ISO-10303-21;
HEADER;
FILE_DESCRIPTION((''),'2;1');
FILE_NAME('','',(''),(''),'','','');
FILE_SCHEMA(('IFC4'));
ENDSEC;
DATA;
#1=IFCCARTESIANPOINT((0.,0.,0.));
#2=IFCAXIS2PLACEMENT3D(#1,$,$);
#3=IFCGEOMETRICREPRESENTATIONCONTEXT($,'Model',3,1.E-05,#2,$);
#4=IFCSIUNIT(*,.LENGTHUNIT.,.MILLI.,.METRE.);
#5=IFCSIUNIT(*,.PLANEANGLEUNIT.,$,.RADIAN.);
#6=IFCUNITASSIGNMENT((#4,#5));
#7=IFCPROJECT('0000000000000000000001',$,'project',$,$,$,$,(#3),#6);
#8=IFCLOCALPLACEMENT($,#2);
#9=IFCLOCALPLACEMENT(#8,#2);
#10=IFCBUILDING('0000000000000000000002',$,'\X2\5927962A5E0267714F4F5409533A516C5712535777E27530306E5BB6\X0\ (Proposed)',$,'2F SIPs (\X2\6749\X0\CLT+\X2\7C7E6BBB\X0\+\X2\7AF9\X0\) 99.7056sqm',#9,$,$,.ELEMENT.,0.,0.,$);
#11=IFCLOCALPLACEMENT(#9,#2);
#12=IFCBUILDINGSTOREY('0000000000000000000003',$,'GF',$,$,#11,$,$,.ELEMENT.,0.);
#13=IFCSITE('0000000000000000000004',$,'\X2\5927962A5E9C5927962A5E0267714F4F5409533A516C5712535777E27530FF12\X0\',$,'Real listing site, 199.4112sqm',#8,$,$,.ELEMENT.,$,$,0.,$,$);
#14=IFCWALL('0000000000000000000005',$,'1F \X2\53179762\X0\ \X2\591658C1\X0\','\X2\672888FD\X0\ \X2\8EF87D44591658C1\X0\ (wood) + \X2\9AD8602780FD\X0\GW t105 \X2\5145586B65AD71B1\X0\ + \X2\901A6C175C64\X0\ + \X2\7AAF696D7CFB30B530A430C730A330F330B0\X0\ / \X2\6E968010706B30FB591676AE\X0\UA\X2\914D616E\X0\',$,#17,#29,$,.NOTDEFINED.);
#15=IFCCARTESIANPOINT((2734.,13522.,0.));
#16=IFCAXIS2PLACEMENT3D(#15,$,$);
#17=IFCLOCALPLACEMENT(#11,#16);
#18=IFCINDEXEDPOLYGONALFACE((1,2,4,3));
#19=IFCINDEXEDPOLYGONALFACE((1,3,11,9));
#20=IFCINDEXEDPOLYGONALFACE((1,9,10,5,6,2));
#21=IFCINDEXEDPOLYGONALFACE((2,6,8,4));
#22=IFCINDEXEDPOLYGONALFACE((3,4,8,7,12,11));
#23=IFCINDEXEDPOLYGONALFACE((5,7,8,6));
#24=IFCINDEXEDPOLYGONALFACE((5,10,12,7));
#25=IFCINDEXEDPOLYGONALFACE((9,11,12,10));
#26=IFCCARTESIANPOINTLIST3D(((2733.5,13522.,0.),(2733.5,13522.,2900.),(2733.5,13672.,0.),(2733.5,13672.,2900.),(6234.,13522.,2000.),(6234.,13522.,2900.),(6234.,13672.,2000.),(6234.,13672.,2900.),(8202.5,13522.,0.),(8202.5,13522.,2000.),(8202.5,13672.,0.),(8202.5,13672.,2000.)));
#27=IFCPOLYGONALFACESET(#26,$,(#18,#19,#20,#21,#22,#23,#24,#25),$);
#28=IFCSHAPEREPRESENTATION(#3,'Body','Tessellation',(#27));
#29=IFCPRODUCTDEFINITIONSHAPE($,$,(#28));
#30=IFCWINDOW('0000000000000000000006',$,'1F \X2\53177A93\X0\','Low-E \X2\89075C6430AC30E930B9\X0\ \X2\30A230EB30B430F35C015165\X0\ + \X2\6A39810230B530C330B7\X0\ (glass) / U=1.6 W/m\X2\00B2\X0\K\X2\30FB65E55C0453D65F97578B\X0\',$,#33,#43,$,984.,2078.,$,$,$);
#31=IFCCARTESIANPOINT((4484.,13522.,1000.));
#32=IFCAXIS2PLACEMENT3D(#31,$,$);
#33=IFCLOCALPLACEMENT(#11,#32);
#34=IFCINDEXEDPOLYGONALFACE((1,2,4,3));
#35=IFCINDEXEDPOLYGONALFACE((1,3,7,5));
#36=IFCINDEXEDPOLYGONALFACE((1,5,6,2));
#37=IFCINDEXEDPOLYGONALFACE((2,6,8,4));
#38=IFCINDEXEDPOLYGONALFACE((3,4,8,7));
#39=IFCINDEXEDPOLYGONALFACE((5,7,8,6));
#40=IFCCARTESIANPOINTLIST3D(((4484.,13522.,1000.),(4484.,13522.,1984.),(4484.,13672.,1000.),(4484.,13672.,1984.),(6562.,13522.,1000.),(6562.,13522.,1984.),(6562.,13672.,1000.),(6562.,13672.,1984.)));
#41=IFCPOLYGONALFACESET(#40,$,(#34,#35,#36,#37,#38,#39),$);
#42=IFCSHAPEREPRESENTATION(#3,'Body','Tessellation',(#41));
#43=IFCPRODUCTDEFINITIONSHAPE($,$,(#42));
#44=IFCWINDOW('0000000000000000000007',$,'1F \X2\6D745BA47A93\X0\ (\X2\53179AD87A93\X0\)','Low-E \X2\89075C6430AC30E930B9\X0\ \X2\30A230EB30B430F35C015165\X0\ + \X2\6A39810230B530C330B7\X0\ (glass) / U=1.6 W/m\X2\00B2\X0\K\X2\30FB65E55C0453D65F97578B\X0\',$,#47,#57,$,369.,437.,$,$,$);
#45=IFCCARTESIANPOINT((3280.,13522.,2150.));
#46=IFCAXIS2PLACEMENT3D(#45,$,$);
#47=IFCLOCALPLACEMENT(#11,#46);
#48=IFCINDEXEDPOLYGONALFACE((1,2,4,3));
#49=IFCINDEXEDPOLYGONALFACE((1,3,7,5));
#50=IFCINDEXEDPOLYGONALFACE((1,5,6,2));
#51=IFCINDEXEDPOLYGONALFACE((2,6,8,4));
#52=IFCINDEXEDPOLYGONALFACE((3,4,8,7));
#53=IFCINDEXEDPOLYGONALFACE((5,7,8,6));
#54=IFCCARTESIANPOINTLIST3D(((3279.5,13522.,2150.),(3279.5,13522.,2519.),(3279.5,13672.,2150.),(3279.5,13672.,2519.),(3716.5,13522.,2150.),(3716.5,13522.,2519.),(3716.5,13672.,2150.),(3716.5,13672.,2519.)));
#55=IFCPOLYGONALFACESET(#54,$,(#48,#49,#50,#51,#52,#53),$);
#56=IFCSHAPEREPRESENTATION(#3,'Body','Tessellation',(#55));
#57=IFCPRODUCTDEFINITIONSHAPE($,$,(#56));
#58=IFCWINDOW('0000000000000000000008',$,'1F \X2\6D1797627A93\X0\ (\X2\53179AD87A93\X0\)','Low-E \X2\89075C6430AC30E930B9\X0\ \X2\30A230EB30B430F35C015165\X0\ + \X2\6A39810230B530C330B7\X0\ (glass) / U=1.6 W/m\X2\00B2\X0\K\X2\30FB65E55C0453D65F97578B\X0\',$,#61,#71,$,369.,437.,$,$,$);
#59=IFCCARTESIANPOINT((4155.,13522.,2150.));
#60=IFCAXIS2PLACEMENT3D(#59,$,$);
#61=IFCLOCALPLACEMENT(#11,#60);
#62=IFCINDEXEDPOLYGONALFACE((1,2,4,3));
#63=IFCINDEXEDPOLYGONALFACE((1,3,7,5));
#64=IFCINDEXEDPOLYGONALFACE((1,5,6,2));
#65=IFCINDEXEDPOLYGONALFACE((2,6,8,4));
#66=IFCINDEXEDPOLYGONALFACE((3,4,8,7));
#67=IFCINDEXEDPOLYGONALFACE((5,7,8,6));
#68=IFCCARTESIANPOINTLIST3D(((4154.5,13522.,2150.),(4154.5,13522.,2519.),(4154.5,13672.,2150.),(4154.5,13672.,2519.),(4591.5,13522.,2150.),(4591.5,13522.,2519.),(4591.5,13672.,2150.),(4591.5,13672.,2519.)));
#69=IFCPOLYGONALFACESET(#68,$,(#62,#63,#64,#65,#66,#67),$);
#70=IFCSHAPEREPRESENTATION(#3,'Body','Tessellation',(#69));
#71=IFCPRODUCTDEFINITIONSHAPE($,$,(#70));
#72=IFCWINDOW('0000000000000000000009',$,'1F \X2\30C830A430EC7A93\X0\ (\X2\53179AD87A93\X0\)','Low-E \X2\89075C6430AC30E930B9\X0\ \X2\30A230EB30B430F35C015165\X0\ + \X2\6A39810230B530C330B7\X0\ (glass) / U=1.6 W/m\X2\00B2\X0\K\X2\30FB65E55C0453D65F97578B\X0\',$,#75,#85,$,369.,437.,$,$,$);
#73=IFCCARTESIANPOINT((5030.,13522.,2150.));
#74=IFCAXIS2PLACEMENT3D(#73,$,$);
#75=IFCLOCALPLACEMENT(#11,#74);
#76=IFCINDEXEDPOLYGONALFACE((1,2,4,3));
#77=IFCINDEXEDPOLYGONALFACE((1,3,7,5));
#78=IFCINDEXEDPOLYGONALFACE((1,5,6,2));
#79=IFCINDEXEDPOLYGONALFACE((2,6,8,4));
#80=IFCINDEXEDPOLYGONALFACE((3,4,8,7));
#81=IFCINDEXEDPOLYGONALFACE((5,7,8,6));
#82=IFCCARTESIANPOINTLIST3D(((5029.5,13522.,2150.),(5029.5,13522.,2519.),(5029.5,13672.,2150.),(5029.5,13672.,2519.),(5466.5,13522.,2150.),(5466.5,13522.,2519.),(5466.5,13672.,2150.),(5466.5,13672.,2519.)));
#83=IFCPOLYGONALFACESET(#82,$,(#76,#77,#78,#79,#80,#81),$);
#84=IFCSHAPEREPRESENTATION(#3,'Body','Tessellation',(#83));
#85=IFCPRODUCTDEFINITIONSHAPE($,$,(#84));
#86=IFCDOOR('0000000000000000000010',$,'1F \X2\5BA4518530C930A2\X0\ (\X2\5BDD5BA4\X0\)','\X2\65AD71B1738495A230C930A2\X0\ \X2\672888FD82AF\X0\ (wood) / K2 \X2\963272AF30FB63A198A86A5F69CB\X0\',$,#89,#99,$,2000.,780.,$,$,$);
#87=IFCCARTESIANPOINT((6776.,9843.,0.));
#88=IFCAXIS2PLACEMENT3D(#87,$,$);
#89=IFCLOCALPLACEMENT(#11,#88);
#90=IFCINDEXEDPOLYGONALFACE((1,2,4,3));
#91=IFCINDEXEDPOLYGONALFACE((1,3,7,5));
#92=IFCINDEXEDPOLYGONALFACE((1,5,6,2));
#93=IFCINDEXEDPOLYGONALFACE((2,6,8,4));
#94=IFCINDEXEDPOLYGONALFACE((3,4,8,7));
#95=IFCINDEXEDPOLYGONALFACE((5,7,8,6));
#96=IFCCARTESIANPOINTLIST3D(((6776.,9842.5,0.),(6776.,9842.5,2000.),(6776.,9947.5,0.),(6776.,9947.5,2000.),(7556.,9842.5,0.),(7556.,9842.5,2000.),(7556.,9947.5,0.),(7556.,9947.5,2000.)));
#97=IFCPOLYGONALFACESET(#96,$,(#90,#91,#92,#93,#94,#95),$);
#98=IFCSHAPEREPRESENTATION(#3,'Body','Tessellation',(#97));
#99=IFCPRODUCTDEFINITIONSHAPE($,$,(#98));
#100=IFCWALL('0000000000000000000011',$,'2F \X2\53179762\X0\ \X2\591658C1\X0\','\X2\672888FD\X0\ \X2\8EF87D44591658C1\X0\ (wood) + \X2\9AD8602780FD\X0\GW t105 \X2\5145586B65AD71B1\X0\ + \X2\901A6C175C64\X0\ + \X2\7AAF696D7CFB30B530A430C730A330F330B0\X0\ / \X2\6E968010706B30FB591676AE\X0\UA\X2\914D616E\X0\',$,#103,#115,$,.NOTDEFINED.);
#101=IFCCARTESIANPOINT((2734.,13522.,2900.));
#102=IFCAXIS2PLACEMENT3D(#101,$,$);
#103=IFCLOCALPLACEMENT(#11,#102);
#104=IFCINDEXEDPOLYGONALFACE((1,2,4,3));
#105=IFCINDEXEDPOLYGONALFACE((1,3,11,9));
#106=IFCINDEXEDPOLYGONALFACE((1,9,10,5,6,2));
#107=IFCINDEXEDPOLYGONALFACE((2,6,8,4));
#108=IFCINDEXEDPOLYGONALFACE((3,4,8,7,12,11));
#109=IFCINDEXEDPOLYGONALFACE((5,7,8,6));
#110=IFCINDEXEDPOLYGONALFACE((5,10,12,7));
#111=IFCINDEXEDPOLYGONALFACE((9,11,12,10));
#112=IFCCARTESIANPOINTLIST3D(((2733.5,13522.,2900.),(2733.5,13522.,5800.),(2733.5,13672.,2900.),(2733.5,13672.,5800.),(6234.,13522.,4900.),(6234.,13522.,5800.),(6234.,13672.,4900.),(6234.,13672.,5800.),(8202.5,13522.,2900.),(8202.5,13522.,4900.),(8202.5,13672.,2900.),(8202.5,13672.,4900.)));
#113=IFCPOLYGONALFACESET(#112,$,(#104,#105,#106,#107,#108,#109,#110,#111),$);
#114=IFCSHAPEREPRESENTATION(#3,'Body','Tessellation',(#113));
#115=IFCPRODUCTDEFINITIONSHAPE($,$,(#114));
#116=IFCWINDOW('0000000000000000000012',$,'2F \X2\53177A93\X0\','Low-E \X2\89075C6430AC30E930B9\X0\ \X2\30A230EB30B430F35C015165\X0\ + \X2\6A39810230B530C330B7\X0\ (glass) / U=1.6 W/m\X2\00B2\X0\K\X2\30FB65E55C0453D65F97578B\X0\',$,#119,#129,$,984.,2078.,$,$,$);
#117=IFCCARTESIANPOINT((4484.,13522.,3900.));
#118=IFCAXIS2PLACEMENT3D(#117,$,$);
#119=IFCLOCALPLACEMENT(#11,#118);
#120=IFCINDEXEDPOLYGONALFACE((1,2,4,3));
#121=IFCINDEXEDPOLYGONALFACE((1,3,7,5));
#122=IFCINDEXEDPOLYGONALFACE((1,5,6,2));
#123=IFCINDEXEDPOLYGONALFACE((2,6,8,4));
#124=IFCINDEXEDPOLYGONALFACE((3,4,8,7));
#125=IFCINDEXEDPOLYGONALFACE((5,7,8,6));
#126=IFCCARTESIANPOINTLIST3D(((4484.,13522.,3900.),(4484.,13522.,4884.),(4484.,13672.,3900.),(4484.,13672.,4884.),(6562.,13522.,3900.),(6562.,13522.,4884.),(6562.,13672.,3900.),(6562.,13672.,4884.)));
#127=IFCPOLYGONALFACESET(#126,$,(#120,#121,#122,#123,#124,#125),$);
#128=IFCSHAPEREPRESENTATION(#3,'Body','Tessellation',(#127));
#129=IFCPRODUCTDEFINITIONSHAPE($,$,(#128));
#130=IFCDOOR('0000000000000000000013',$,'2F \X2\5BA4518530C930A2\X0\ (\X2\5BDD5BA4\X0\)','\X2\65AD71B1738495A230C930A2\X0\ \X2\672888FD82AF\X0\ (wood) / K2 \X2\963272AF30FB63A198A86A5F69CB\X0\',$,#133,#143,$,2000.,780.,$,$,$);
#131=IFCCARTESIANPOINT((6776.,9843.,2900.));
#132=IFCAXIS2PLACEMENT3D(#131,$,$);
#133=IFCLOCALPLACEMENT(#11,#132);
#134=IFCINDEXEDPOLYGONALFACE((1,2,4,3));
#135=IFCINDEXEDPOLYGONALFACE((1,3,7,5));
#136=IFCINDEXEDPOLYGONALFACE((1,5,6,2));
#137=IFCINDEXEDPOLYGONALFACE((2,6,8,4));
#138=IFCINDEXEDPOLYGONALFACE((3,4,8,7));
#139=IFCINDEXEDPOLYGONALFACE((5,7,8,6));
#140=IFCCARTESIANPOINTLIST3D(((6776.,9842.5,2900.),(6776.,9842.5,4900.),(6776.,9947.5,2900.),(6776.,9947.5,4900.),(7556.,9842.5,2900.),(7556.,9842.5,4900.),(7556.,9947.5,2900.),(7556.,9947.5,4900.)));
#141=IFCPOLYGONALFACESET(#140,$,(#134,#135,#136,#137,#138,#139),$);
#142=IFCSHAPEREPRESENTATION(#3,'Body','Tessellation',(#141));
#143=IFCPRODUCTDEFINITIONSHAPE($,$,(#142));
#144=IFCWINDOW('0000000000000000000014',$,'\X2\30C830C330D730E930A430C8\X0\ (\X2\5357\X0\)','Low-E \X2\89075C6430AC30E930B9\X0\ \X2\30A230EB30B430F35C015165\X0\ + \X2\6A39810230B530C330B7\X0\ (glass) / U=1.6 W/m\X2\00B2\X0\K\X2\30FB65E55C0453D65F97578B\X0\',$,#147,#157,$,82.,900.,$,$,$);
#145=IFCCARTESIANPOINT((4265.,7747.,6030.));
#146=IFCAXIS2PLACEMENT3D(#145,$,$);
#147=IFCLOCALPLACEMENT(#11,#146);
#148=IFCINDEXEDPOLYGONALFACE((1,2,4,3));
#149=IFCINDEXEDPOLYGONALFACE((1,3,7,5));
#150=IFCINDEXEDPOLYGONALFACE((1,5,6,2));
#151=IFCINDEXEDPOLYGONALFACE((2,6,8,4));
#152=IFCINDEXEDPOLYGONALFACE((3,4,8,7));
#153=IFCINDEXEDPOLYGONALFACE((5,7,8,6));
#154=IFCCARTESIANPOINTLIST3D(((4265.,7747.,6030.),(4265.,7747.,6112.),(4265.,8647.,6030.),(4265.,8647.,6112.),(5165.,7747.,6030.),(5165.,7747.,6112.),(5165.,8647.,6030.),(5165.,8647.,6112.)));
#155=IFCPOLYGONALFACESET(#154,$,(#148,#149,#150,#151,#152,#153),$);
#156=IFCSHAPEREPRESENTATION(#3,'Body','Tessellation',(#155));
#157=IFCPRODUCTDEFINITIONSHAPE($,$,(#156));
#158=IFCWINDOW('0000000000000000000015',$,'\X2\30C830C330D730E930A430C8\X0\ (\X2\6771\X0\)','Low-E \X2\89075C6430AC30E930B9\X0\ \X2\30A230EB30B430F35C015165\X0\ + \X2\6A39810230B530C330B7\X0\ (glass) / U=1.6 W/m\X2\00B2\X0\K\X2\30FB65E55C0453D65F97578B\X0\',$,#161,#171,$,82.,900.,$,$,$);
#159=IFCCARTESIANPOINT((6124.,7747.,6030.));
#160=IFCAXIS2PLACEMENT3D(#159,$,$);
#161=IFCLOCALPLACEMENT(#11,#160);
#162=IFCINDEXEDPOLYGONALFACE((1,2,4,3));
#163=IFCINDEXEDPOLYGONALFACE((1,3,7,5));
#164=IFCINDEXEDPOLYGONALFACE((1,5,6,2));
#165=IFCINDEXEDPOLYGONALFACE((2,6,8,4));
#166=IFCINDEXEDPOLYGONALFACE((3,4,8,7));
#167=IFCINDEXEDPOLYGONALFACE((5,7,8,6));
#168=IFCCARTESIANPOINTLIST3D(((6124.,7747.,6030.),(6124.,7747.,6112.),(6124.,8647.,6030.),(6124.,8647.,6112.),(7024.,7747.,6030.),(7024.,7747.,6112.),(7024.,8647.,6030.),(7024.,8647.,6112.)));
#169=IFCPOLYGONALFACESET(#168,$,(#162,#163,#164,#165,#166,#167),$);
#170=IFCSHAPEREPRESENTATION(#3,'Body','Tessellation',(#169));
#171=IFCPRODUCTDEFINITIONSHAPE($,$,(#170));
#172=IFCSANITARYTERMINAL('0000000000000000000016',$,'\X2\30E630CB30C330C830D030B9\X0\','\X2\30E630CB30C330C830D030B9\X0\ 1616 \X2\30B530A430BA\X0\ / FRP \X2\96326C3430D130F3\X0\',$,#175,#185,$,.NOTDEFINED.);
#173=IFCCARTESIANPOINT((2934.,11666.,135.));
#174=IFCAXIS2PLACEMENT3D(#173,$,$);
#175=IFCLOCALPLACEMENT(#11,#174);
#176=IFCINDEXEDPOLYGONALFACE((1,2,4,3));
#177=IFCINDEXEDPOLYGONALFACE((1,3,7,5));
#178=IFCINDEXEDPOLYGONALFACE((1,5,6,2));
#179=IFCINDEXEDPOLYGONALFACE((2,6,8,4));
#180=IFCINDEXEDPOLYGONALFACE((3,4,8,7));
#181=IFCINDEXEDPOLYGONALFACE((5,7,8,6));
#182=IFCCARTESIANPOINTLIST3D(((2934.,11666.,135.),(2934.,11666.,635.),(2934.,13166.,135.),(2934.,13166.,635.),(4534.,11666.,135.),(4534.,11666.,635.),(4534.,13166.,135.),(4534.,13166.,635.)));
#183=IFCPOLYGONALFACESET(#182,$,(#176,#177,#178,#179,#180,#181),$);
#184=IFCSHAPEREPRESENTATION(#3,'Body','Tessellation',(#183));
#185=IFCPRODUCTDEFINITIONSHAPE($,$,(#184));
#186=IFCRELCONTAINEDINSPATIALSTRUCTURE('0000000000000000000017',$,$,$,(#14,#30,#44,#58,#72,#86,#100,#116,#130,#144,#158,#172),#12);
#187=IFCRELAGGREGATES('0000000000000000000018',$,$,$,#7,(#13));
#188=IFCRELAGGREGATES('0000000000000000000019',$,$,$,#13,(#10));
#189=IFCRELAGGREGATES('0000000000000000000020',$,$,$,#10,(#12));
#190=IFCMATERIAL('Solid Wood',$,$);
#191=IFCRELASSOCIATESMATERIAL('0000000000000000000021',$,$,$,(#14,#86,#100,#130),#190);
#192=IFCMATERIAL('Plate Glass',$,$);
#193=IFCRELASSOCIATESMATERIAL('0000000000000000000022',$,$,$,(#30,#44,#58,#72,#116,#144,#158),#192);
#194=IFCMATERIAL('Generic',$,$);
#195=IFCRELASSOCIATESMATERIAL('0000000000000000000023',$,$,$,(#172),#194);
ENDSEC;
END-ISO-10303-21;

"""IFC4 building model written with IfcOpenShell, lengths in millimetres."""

from ifc_helpers import new_model, si_unit, frame, frame_2d, origin, place, context, project, spatial, rectangle, extrude, material, element, fill, save


model = new_model("IFC4")

# Units and contexts
model_context = context("Model", 3, precision=1e-05, world=origin())
ifc_project = project(units=[si_unit("LENGTHUNIT", "METRE", prefix="MILLI"), si_unit("PLANEANGLEUNIT", "RADIAN")], contexts=[model_context])

# Site, building, storey
site_placement = place(None, origin())
site = spatial("IfcSite", under=ifc_project, at=site_placement, Name="大阪府大阪市東住吉区公園南矢田２", ObjectType="Real listing site, 199.4112sqm", CompositionType="ELEMENT", RefElevation=0.0)
building_placement = place(site_placement, origin())
building = spatial("IfcBuilding", under=site, at=building_placement, Name="大阪市東住吉区公園南矢田の家 (Proposed)", ObjectType="2F SIPs (杉CLT+籾殻+竹) 99.7056sqm", CompositionType="ELEMENT", ElevationOfRefHeight=0.0, ElevationOfTerrain=0.0)
storey_placement = place(building_placement, origin())
storey = spatial("IfcBuildingStorey", under=building, at=storey_placement, Name="GF", CompositionType="ELEMENT", Elevation=0.0)

# Wall, openings, windows
ifc_material_1 = material(Name="Solid Wood")
wall_1_placement = place(storey_placement, frame((2734.0, 13522.0, 0.0)))
wall_1 = element("IfcWall", 1, at=wall_1_placement, inside=storey, material=ifc_material_1, Name="1F 北面 外壁", Description="木製 軸組外壁 (wood) + 高性能GW t105 充填断熱 + 通気層 + 窯業系サイディング / 準耐火・外皮UA配慮", PredefinedType="NOTDEFINED", context=model_context, shape_type="SweptSolid", body=[
    extrude(rectangle(XDim=5469.0, YDim=150.0, at=frame_2d((2734.0, 75.0))), frame((2734.0, 13522.0, 0.0)), (0.0, 0.0, 1.0), 2900.0),
])
opening_1_placement = place(storey_placement, frame((4484.0, 13522.0, 1000.0)))
opening_1 = element("IfcOpeningElement", 2, at=opening_1_placement, cuts=wall_1, PredefinedType="NOTDEFINED", context=model_context, shape_type="SweptSolid", body=[
    extrude(rectangle(XDim=2078.0, YDim=150.0, at=frame_2d((1039.0, 75.0))), frame((4484.0, 13522.0, 1000.0)), (0.0, 0.0, 1.0), 984.0),
])
opening_2_placement = place(storey_placement, frame((3280.0, 13522.0, 2150.0)))
opening_2 = element("IfcOpeningElement", 3, at=opening_2_placement, cuts=wall_1, PredefinedType="NOTDEFINED", context=model_context, shape_type="SweptSolid", body=[
    extrude(rectangle(XDim=437.0, YDim=150.0, at=frame_2d((218.0, 75.0))), frame((3280.0, 13522.0, 2150.0)), (0.0, 0.0, 1.0), 369.0),
])
opening_3_placement = place(storey_placement, frame((4155.0, 13522.0, 2150.0)))
opening_3 = element("IfcOpeningElement", 4, at=opening_3_placement, cuts=wall_1, PredefinedType="NOTDEFINED", context=model_context, shape_type="SweptSolid", body=[
    extrude(rectangle(XDim=437.0, YDim=150.0, at=frame_2d((218.0, 75.0))), frame((4155.0, 13522.0, 2150.0)), (0.0, 0.0, 1.0), 369.0),
])
opening_4_placement = place(storey_placement, frame((5030.0, 13522.0, 2150.0)))
opening_4 = element("IfcOpeningElement", 5, at=opening_4_placement, cuts=wall_1, PredefinedType="NOTDEFINED", context=model_context, shape_type="SweptSolid", body=[
    extrude(rectangle(XDim=437.0, YDim=150.0, at=frame_2d((218.0, 75.0))), frame((5030.0, 13522.0, 2150.0)), (0.0, 0.0, 1.0), 369.0),
])
ifc_material_2 = material(Name="Plate Glass")
window_1_placement = place(storey_placement, frame((4484.0, 13522.0, 1000.0)))
window_1 = element("IfcWindow", 6, at=window_1_placement, inside=storey, material=ifc_material_2, Name="1F 北窓", Description="Low-E 複層ガラス アルゴン封入 + 樹脂サッシ (glass) / U=1.6 W/m²K・日射取得型", OverallHeight=984.0, OverallWidth=2078.0, context=model_context, shape_type="SweptSolid", body=[
    extrude(rectangle(XDim=2078.0, YDim=150.0, at=frame_2d((1039.0, 75.0))), frame((4484.0, 13522.0, 1000.0)), (0.0, 0.0, 1.0), 984.0),
])
fill(opening_1, window_1)
window_2_placement = place(storey_placement, frame((3280.0, 13522.0, 2150.0)))
window_2 = element("IfcWindow", 7, at=window_2_placement, inside=storey, material=ifc_material_2, Name="1F 浴室窓 (北高窓)", Description="Low-E 複層ガラス アルゴン封入 + 樹脂サッシ (glass) / U=1.6 W/m²K・日射取得型", OverallHeight=369.0, OverallWidth=437.0, context=model_context, shape_type="SweptSolid", body=[
    extrude(rectangle(XDim=437.0, YDim=150.0, at=frame_2d((218.0, 75.0))), frame((3280.0, 13522.0, 2150.0)), (0.0, 0.0, 1.0), 369.0),
])
fill(opening_2, window_2)
window_3_placement = place(storey_placement, frame((4155.0, 13522.0, 2150.0)))
window_3 = element("IfcWindow", 8, at=window_3_placement, inside=storey, material=ifc_material_2, Name="1F 洗面窓 (北高窓)", Description="Low-E 複層ガラス アルゴン封入 + 樹脂サッシ (glass) / U=1.6 W/m²K・日射取得型", OverallHeight=369.0, OverallWidth=437.0, context=model_context, shape_type="SweptSolid", body=[
    extrude(rectangle(XDim=437.0, YDim=150.0, at=frame_2d((218.0, 75.0))), frame((4155.0, 13522.0, 2150.0)), (0.0, 0.0, 1.0), 369.0),
])
fill(opening_3, window_3)
window_4_placement = place(storey_placement, frame((5030.0, 13522.0, 2150.0)))
window_4 = element("IfcWindow", 9, at=window_4_placement, inside=storey, material=ifc_material_2, Name="1F トイレ窓 (北高窓)", Description="Low-E 複層ガラス アルゴン封入 + 樹脂サッシ (glass) / U=1.6 W/m²K・日射取得型", OverallHeight=369.0, OverallWidth=437.0, context=model_context, shape_type="SweptSolid", body=[
    extrude(rectangle(XDim=437.0, YDim=150.0, at=frame_2d((218.0, 75.0))), frame((5030.0, 13522.0, 2150.0)), (0.0, 0.0, 1.0), 369.0),
])
fill(opening_4, window_4)

# Door
door_1_placement = place(storey_placement, frame((6776.0, 9843.0, 0.0)))
element("IfcDoor", 10, at=door_1_placement, inside=storey, material=ifc_material_1, Name="1F 室内ドア (寝室)", Description="断熱玄関ドア 木製芯 (wood) / K2 防犯・採風機構", OverallHeight=2000.0, OverallWidth=780.0, context=model_context, shape_type="SweptSolid", body=[
    extrude(rectangle(XDim=780.0, YDim=105.0, at=frame_2d((390.0, 52.0))), frame((6776.0, 9843.0, 0.0)), (0.0, 0.0, 1.0), 2000.0),
])

# Wall, opening, window
wall_2_placement = place(storey_placement, frame((2734.0, 13522.0, 2900.0)))
wall_2 = element("IfcWall", 11, at=wall_2_placement, inside=storey, material=ifc_material_1, Name="2F 北面 外壁", Description="木製 軸組外壁 (wood) + 高性能GW t105 充填断熱 + 通気層 + 窯業系サイディング / 準耐火・外皮UA配慮", PredefinedType="NOTDEFINED", context=model_context, shape_type="SweptSolid", body=[
    extrude(rectangle(XDim=5469.0, YDim=150.0, at=frame_2d((2734.0, 75.0))), frame((2734.0, 13522.0, 2900.0)), (0.0, 0.0, 1.0), 2900.0),
])
opening_5_placement = place(storey_placement, frame((4484.0, 13522.0, 3900.0)))
opening_5 = element("IfcOpeningElement", 12, at=opening_5_placement, cuts=wall_2, PredefinedType="NOTDEFINED", context=model_context, shape_type="SweptSolid", body=[
    extrude(rectangle(XDim=2078.0, YDim=150.0, at=frame_2d((1039.0, 75.0))), frame((4484.0, 13522.0, 3900.0)), (0.0, 0.0, 1.0), 984.0),
])
window_5_placement = place(storey_placement, frame((4484.0, 13522.0, 3900.0)))
window_5 = element("IfcWindow", 13, at=window_5_placement, inside=storey, material=ifc_material_2, Name="2F 北窓", Description="Low-E 複層ガラス アルゴン封入 + 樹脂サッシ (glass) / U=1.6 W/m²K・日射取得型", OverallHeight=984.0, OverallWidth=2078.0, context=model_context, shape_type="SweptSolid", body=[
    extrude(rectangle(XDim=2078.0, YDim=150.0, at=frame_2d((1039.0, 75.0))), frame((4484.0, 13522.0, 3900.0)), (0.0, 0.0, 1.0), 984.0),
])
fill(opening_5, window_5)

# Door
door_2_placement = place(storey_placement, frame((6776.0, 9843.0, 2900.0)))
element("IfcDoor", 14, at=door_2_placement, inside=storey, material=ifc_material_1, Name="2F 室内ドア (寝室)", Description="断熱玄関ドア 木製芯 (wood) / K2 防犯・採風機構", OverallHeight=2000.0, OverallWidth=780.0, context=model_context, shape_type="SweptSolid", body=[
    extrude(rectangle(XDim=780.0, YDim=105.0, at=frame_2d((390.0, 52.0))), frame((6776.0, 9843.0, 2900.0)), (0.0, 0.0, 1.0), 2000.0),
])

# Windows
window_6_placement = place(storey_placement, frame((4265.0, 7747.0, 6030.0)))
element("IfcWindow", 15, at=window_6_placement, inside=storey, material=ifc_material_2, Name="トップライト (南)", Description="Low-E 複層ガラス アルゴン封入 + 樹脂サッシ (glass) / U=1.6 W/m²K・日射取得型", OverallHeight=82.0, OverallWidth=900.0, context=model_context, shape_type="SweptSolid", body=[
    extrude(rectangle(XDim=900.0, YDim=900.0, at=frame_2d((450.0, 450.0))), frame((4265.0, 7747.0, 6030.0)), (0.0, 0.0, 1.0), 82.0),
])
window_7_placement = place(storey_placement, frame((6124.0, 7747.0, 6030.0)))
element("IfcWindow", 16, at=window_7_placement, inside=storey, material=ifc_material_2, Name="トップライト (東)", Description="Low-E 複層ガラス アルゴン封入 + 樹脂サッシ (glass) / U=1.6 W/m²K・日射取得型", OverallHeight=82.0, OverallWidth=900.0, context=model_context, shape_type="SweptSolid", body=[
    extrude(rectangle(XDim=900.0, YDim=900.0, at=frame_2d((450.0, 450.0))), frame((6124.0, 7747.0, 6030.0)), (0.0, 0.0, 1.0), 82.0),
])

# Sanitary terminal
ifc_material_3 = material(Name="Generic")
sanitary_terminal_1_placement = place(storey_placement, frame((2934.0, 11666.0, 135.0)))
element("IfcSanitaryTerminal", 17, at=sanitary_terminal_1_placement, inside=storey, material=ifc_material_3, Name="ユニットバス", Description="ユニットバス 1616 サイズ / FRP 防水パン", PredefinedType="NOTDEFINED", context=model_context, shape_type="SweptSolid", body=[
    extrude(rectangle(XDim=1600.0, YDim=1500.0, at=frame_2d((800.0, 750.0))), frame((2934.0, 11666.0, 135.0)), (0.0, 0.0, 1.0), 500.0),
])

save(model, "model.ifc")
